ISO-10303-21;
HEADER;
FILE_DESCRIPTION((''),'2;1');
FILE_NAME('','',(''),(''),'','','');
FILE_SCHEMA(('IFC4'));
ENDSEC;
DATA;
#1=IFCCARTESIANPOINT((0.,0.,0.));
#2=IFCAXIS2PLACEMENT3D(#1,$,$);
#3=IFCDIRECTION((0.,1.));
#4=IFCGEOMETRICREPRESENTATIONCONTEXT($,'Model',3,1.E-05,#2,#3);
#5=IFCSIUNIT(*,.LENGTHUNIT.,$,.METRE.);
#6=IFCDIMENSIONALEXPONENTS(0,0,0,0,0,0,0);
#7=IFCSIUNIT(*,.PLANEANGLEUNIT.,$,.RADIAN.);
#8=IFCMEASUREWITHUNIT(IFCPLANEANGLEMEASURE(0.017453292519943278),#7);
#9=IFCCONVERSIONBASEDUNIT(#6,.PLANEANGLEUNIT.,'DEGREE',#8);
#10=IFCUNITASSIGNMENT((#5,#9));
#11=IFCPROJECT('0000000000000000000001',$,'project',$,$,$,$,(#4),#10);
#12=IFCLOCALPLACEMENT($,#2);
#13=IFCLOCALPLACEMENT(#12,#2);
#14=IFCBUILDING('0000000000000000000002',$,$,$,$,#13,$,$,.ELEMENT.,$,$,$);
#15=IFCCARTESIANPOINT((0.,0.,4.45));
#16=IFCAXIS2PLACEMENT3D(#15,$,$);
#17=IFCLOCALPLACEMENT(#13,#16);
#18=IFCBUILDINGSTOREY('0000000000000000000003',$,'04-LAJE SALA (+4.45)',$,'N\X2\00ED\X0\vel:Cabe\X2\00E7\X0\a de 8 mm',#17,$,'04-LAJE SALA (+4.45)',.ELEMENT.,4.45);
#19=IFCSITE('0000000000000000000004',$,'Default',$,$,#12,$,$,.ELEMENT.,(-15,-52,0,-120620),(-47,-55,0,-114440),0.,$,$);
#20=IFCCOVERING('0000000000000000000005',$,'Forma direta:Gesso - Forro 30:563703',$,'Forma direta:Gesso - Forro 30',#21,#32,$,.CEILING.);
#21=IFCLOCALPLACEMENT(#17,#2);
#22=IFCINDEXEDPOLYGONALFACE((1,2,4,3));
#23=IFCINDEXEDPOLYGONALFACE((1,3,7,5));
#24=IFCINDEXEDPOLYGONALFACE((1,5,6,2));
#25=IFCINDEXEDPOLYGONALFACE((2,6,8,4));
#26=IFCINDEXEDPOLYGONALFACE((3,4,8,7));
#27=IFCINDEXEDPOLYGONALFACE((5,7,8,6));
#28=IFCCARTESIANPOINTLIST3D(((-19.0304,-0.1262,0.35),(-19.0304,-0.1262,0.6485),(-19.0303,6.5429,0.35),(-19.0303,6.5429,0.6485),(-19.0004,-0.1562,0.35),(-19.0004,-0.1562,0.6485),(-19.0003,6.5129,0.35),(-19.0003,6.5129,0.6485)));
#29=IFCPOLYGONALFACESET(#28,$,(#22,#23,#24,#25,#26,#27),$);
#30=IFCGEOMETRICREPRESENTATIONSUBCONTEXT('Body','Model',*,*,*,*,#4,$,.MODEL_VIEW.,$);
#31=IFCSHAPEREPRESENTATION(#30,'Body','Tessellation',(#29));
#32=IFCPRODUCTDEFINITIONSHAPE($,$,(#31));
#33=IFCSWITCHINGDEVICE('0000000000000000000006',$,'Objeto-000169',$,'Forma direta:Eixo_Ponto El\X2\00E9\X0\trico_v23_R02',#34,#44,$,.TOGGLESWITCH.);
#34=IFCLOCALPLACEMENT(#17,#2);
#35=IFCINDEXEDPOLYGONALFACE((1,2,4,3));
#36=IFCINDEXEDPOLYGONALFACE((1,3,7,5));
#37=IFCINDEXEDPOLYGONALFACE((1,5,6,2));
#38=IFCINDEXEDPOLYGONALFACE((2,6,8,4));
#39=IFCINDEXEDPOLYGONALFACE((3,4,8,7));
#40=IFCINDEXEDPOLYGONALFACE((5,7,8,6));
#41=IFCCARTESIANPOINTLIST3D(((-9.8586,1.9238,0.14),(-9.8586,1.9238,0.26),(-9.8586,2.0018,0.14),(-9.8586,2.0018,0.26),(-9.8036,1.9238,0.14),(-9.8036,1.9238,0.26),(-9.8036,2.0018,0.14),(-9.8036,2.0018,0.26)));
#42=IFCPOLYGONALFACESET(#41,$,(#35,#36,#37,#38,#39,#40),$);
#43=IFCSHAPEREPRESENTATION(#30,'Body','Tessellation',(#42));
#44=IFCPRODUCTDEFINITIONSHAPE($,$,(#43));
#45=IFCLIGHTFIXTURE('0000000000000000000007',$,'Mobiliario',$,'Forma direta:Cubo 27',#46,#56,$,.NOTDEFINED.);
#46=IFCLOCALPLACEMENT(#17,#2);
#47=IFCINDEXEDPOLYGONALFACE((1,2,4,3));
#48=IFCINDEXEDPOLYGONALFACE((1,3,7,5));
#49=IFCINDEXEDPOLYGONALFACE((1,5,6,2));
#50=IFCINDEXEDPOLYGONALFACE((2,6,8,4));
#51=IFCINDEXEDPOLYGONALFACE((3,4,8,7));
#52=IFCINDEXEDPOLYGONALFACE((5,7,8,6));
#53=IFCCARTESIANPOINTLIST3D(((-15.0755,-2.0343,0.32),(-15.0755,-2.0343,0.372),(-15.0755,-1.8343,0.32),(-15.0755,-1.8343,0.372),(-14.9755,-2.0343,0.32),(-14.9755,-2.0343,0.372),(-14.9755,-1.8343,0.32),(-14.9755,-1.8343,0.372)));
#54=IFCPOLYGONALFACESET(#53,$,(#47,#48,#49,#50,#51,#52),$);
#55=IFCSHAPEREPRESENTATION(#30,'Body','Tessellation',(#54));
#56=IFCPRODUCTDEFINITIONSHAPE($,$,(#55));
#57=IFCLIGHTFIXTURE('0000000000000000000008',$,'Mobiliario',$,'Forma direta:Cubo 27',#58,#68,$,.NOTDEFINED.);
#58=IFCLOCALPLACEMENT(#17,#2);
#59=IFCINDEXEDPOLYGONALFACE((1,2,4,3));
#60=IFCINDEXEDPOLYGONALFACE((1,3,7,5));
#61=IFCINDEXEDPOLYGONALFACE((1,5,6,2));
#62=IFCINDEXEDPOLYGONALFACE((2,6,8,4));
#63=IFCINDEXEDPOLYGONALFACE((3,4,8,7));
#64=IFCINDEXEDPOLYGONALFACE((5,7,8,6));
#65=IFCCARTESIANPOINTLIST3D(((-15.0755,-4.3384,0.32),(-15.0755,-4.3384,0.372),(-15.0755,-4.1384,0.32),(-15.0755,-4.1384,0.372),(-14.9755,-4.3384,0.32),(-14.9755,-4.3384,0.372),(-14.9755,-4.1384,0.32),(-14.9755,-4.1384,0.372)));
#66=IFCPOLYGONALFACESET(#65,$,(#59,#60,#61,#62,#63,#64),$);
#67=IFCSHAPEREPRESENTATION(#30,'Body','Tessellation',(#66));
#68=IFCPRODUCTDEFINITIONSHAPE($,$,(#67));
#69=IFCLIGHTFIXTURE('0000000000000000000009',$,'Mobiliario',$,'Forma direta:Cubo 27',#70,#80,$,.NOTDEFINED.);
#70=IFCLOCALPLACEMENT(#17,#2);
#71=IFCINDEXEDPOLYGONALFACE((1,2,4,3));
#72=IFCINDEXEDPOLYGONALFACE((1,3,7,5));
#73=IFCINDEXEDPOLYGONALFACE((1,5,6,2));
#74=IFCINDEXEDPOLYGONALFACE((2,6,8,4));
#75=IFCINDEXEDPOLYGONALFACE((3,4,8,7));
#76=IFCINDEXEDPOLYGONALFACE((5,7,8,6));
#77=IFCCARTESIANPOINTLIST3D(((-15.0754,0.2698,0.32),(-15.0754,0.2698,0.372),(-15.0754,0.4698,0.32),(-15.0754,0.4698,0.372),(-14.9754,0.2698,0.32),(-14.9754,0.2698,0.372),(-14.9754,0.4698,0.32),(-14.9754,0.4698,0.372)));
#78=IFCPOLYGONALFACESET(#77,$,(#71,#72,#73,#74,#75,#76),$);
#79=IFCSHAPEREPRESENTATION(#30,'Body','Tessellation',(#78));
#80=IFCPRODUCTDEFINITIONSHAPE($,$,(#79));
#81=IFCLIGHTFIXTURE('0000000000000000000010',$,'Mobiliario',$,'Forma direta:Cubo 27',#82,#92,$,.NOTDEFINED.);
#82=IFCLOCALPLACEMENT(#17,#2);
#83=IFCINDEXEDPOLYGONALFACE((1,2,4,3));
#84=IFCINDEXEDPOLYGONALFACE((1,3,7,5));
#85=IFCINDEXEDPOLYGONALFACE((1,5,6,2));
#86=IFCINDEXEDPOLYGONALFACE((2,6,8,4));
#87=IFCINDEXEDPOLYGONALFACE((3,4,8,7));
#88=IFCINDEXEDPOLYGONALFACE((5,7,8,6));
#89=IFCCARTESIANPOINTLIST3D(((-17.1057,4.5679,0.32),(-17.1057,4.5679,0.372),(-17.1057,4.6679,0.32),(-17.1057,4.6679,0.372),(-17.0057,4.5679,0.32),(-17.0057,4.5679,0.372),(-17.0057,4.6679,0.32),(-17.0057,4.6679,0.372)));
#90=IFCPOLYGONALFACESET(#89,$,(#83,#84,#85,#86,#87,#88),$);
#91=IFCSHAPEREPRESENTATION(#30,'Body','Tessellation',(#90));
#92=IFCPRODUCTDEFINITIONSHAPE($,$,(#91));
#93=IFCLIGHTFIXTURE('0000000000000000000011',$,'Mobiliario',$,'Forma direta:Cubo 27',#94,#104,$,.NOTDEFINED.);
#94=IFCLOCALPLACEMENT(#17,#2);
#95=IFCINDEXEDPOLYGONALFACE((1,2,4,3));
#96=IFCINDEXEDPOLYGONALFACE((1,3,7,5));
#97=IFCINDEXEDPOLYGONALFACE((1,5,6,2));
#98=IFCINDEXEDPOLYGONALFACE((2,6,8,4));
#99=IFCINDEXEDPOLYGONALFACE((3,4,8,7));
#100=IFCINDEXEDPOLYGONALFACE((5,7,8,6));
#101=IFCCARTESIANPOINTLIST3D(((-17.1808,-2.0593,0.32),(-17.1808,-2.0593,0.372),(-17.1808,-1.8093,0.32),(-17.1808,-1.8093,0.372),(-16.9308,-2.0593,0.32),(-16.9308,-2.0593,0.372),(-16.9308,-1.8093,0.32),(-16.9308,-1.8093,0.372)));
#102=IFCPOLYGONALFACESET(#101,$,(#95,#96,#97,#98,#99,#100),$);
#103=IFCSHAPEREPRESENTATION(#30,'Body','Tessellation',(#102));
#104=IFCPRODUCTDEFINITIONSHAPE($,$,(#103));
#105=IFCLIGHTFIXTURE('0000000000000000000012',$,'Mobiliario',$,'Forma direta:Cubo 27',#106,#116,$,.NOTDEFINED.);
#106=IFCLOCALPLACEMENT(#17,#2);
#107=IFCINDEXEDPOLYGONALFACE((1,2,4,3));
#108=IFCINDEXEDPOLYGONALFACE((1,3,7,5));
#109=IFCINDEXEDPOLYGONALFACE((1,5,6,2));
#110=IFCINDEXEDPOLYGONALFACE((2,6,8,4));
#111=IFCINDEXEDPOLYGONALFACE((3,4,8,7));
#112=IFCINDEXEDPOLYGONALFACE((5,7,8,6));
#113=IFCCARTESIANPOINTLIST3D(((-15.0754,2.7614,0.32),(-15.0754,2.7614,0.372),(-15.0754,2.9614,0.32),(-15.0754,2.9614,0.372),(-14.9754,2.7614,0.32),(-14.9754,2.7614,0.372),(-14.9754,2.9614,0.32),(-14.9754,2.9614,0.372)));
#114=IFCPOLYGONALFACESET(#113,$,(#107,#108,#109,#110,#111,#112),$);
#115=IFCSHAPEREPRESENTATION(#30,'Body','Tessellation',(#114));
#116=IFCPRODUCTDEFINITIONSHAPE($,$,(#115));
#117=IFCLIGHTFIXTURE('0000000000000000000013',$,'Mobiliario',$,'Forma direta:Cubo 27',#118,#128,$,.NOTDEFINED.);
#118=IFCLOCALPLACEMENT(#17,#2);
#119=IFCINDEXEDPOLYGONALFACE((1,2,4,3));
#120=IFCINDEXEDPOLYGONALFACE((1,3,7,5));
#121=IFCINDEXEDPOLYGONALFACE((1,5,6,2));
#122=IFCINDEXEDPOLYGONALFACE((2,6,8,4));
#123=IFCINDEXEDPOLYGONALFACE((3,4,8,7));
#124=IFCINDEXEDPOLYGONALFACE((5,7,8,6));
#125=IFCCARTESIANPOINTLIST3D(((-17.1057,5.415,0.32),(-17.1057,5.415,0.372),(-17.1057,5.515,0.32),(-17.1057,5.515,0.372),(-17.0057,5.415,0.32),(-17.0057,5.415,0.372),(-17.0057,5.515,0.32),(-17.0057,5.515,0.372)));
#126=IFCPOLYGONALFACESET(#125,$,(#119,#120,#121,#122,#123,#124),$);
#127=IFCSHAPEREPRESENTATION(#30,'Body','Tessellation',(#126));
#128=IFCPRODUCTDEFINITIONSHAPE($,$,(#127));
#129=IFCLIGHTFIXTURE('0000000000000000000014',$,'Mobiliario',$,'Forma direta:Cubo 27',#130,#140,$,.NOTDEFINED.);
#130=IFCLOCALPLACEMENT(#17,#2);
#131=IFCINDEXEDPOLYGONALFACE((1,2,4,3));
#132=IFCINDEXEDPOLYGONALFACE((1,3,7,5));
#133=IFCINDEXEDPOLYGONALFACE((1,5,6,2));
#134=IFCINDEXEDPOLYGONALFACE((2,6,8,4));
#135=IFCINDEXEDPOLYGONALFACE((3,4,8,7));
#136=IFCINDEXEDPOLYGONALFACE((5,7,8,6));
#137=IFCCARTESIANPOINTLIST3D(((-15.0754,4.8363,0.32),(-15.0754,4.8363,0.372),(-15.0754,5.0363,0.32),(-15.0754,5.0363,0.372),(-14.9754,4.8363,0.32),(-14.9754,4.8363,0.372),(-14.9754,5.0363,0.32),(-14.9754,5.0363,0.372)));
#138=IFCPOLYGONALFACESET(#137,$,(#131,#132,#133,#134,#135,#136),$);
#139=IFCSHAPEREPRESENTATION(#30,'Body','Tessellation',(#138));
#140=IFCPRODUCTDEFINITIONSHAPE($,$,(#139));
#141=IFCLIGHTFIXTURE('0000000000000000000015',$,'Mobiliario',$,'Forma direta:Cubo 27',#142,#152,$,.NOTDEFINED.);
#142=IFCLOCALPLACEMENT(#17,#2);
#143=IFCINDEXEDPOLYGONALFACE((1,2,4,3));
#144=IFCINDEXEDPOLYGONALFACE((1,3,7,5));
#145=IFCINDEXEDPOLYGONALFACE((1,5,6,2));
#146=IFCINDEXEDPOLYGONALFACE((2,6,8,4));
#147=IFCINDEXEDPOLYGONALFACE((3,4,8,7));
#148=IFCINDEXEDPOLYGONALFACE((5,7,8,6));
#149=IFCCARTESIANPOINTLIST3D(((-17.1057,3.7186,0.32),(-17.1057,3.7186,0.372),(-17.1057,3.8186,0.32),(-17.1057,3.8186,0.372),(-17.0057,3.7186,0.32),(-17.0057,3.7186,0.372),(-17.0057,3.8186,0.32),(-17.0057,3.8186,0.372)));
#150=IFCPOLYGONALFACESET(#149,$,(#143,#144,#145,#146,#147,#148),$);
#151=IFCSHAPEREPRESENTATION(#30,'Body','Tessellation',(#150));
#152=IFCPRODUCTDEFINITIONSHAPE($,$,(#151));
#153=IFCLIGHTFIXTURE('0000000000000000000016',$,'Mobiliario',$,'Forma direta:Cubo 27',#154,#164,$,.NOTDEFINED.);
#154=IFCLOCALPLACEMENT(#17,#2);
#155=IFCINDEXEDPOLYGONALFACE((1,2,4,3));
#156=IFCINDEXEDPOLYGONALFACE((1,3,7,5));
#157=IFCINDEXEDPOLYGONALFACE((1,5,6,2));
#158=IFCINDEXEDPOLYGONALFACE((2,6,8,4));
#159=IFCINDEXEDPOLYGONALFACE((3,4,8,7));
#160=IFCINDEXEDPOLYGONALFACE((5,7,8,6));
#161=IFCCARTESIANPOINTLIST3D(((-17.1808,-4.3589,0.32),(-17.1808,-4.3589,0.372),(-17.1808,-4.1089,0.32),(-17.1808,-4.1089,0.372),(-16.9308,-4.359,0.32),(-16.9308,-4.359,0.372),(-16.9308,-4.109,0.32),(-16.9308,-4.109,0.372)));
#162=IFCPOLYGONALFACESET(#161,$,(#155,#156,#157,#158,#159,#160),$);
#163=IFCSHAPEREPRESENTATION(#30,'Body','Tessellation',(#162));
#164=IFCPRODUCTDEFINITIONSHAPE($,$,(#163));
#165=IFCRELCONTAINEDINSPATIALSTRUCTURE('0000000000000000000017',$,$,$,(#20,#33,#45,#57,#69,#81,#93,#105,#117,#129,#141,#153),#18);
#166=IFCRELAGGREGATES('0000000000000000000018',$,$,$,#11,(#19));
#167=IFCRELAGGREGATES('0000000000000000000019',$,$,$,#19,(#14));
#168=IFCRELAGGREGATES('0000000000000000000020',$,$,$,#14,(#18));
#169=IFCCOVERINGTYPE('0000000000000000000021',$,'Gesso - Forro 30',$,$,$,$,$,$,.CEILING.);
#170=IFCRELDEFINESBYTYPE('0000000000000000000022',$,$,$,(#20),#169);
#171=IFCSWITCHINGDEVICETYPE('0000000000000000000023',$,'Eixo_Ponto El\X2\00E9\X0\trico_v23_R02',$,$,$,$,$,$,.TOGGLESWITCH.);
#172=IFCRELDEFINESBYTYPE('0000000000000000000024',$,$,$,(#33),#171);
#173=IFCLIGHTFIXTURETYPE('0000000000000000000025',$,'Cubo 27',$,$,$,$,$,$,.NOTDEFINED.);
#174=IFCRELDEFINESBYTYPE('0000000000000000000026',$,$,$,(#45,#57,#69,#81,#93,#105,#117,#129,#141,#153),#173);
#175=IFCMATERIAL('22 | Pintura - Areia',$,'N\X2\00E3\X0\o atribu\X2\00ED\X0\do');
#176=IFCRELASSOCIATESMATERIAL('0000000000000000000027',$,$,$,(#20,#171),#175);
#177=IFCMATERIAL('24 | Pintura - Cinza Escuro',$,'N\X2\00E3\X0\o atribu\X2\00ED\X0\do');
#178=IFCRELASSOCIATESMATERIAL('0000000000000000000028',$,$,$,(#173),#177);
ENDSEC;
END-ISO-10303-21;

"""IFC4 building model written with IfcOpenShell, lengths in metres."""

from ifc_helpers import new_model, entity, si_unit, converted_unit, direction, frame, origin, place, context, subcontext, project, spatial, indexed_curve, outline, extrude, material, type_object, element, save


model = new_model("IFC4")

# Units and contexts
model_context = context("Model", 3, precision=1e-05, world=origin(), true_north=direction((0.0, 1.0)))
body_context = subcontext(model_context, "Body", "Model", "MODEL_VIEW")
ifc_project = project(units=[si_unit("LENGTHUNIT", "METRE"), converted_unit("PLANEANGLEUNIT", "DEGREE", entity("IfcPlaneAngleMeasure", 0.017453292519943278), si_unit("PLANEANGLEUNIT", "RADIAN"), dimensions=[0, 0, 0, 0, 0, 0, 0])], contexts=[model_context])

# Site, building, storey
site_placement = place(None, origin())
site = spatial("IfcSite", under=ifc_project, at=site_placement, Name="Default", CompositionType="ELEMENT", RefLatitude=(-15, -52, 0, -120620), RefLongitude=(-47, -55, 0, -114440), RefElevation=0.0)
building_placement = place(site_placement, origin())
building = spatial("IfcBuilding", under=site, at=building_placement, CompositionType="ELEMENT")
storey_placement = place(building_placement, frame((0.0, 0.0, 4.45)))
storey = spatial("IfcBuildingStorey", under=building, at=storey_placement, Name="04-LAJE SALA (+4.45)", ObjectType="Nível:Cabeça de 8 mm", LongName="04-LAJE SALA (+4.45)", CompositionType="ELEMENT", Elevation=4.45)

# Covering
ifc_material_1 = material(Name="22 | Pintura - Areia", Category="Não atribuído")
covering_type = type_object("IfcCoveringType", Name="Gesso - Forro 30", PredefinedType="CEILING")
covering_1_placement = place(storey_placement, origin())
element("IfcCovering", 1, at=covering_1_placement, inside=storey, type_object=covering_type, material=ifc_material_1, Name="Forma direta:Gesso - Forro 30:563703", ObjectType="Forma direta:Gesso - Forro 30", PredefinedType="CEILING", context=body_context, shape_type="SweptSolid", body=[
    extrude(outline(indexed_curve([(2.3367, -2.3579), (2.3791, -2.3579), (-2.3367, 2.3579), (-2.3791, 2.3579), (2.3367, -2.3579)], self_intersect=False)), frame((-19.0154, 3.1933, 0.35), z_axis=(0.0, 0.0, 1.0), x_axis=(-0.707098, 0.707116, 0.0)), (0.0, 0.0, 1.0), 0.2985),
])

# Switching device
switching_device_type = type_object("IfcSwitchingDeviceType", Name="Eixo_Ponto Elétrico_v23_R02", PredefinedType="TOGGLESWITCH", material=ifc_material_1)
switching_device_placement = place(storey_placement, origin())
element("IfcSwitchingDevice", 2, at=switching_device_placement, inside=storey, type_object=switching_device_type, Name="Objeto-000169", ObjectType="Forma direta:Eixo_Ponto Elétrico_v23_R02", PredefinedType="TOGGLESWITCH", context=body_context, shape_type="SweptSolid", body=[
    extrude(outline(indexed_curve([(-0.0275, -0.039), (0.0275, -0.039), (0.0275, 0.039), (-0.0275, 0.039), (-0.0275, -0.039)], self_intersect=False)), frame((-9.8311, 1.9628, 0.14)), (0.0, 0.0, 1.0), 0.12),
])

# Light fixtures
ifc_material_2 = material(Name="24 | Pintura - Cinza Escuro", Category="Não atribuído")
light_fixture_type = type_object("IfcLightFixtureType", Name="Cubo 27", PredefinedType="NOTDEFINED", material=ifc_material_2)
light_fixture_1_placement = place(storey_placement, origin())
element("IfcLightFixture", 3, at=light_fixture_1_placement, inside=storey, type_object=light_fixture_type, Name="Mobiliario", ObjectType="Forma direta:Cubo 27", PredefinedType="NOTDEFINED", context=body_context, shape_type="SweptSolid", body=[
    extrude(outline(indexed_curve([(-0.1, -0.05), (0.1, -0.05), (0.1, 0.05), (-0.1, 0.05), (-0.1, -0.05)], self_intersect=False)), frame((-15.0255, -1.9343, 0.32), z_axis=(0.0, 0.0, 1.0), x_axis=(-0.000013, -1.0, 0.0)), (0.0, 0.0, 1.0), 0.052),
])
light_fixture_2_placement = place(storey_placement, origin())
element("IfcLightFixture", 4, at=light_fixture_2_placement, inside=storey, type_object=light_fixture_type, Name="Mobiliario", ObjectType="Forma direta:Cubo 27", PredefinedType="NOTDEFINED", context=body_context, shape_type="SweptSolid", body=[
    extrude(outline(indexed_curve([(-0.1, -0.05), (0.1, -0.05), (0.1, 0.05), (-0.1, 0.05), (-0.1, -0.05)], self_intersect=False)), frame((-15.0255, -4.2384, 0.32), z_axis=(0.0, 0.0, 1.0), x_axis=(-0.000013, -1.0, 0.0)), (0.0, 0.0, 1.0), 0.052),
])
light_fixture_3_placement = place(storey_placement, origin())
element("IfcLightFixture", 5, at=light_fixture_3_placement, inside=storey, type_object=light_fixture_type, Name="Mobiliario", ObjectType="Forma direta:Cubo 27", PredefinedType="NOTDEFINED", context=body_context, shape_type="SweptSolid", body=[
    extrude(outline(indexed_curve([(-0.1, -0.05), (0.1, -0.05), (0.1, 0.05), (-0.1, 0.05), (-0.1, -0.05)], self_intersect=False)), frame((-15.0254, 0.3698, 0.32), z_axis=(0.0, 0.0, 1.0), x_axis=(-0.000013, -1.0, 0.0)), (0.0, 0.0, 1.0), 0.052),
])
light_fixture_4_placement = place(storey_placement, origin())
element("IfcLightFixture", 6, at=light_fixture_4_placement, inside=storey, type_object=light_fixture_type, Name="Mobiliario", ObjectType="Forma direta:Cubo 27", PredefinedType="NOTDEFINED", context=body_context, shape_type="SweptSolid", body=[
    extrude(outline(indexed_curve([(-0.05, -0.05), (0.05, -0.05), (0.05, 0.05), (-0.05, 0.05), (-0.05, -0.05)], self_intersect=False)), frame((-17.0557, 4.6179, 0.32), z_axis=(0.0, 0.0, 1.0), x_axis=(-0.000013, -1.0, 0.0)), (0.0, 0.0, 1.0), 0.052),
])
light_fixture_5_placement = place(storey_placement, origin())
element("IfcLightFixture", 7, at=light_fixture_5_placement, inside=storey, type_object=light_fixture_type, Name="Mobiliario", ObjectType="Forma direta:Cubo 27", PredefinedType="NOTDEFINED", context=body_context, shape_type="SweptSolid", body=[
    extrude(outline(indexed_curve([(-0.125, -0.125), (0.125, -0.125), (0.125, 0.125), (-0.125, 0.125), (-0.125, -0.125)], self_intersect=False)), frame((-17.0558, -1.9343, 0.32), z_axis=(0.0, 0.0, 1.0), x_axis=(-0.000013, -1.0, 0.0)), (0.0, 0.0, 1.0), 0.052),
])
light_fixture_6_placement = place(storey_placement, origin())
element("IfcLightFixture", 8, at=light_fixture_6_placement, inside=storey, type_object=light_fixture_type, Name="Mobiliario", ObjectType="Forma direta:Cubo 27", PredefinedType="NOTDEFINED", context=body_context, shape_type="SweptSolid", body=[
    extrude(outline(indexed_curve([(-0.1, -0.05), (0.1, -0.05), (0.1, 0.05), (-0.1, 0.05), (-0.1, -0.05)], self_intersect=False)), frame((-15.0254, 2.8614, 0.32), z_axis=(0.0, 0.0, 1.0), x_axis=(-0.000013, -1.0, 0.0)), (0.0, 0.0, 1.0), 0.052),
])
light_fixture_7_placement = place(storey_placement, origin())
element("IfcLightFixture", 9, at=light_fixture_7_placement, inside=storey, type_object=light_fixture_type, Name="Mobiliario", ObjectType="Forma direta:Cubo 27", PredefinedType="NOTDEFINED", context=body_context, shape_type="SweptSolid", body=[
    extrude(outline(indexed_curve([(-0.05, -0.05), (0.05, -0.05), (0.05, 0.05), (-0.05, 0.05), (-0.05, -0.05)], self_intersect=False)), frame((-17.0557, 5.465, 0.32), z_axis=(0.0, 0.0, 1.0), x_axis=(-0.000013, -1.0, 0.0)), (0.0, 0.0, 1.0), 0.052),
])
light_fixture_8_placement = place(storey_placement, origin())
element("IfcLightFixture", 10, at=light_fixture_8_placement, inside=storey, type_object=light_fixture_type, Name="Mobiliario", ObjectType="Forma direta:Cubo 27", PredefinedType="NOTDEFINED", context=body_context, shape_type="SweptSolid", body=[
    extrude(outline(indexed_curve([(-0.1, -0.05), (0.1, -0.05), (0.1, 0.05), (-0.1, 0.05), (-0.1, -0.05)], self_intersect=False)), frame((-15.0254, 4.9363, 0.32), z_axis=(0.0, 0.0, 1.0), x_axis=(-0.000013, -1.0, 0.0)), (0.0, 0.0, 1.0), 0.052),
])
light_fixture_9_placement = place(storey_placement, origin())
element("IfcLightFixture", 11, at=light_fixture_9_placement, inside=storey, type_object=light_fixture_type, Name="Mobiliario", ObjectType="Forma direta:Cubo 27", PredefinedType="NOTDEFINED", context=body_context, shape_type="SweptSolid", body=[
    extrude(outline(indexed_curve([(-0.05, -0.05), (0.05, -0.05), (0.05, 0.05), (-0.05, 0.05), (-0.05, -0.05)], self_intersect=False)), frame((-17.0557, 3.7686, 0.32), z_axis=(0.0, 0.0, 1.0), x_axis=(-0.000013, -1.0, 0.0)), (0.0, 0.0, 1.0), 0.052),
])
light_fixture_10_placement = place(storey_placement, origin())
element("IfcLightFixture", 12, at=light_fixture_10_placement, inside=storey, type_object=light_fixture_type, Name="Mobiliario", ObjectType="Forma direta:Cubo 27", PredefinedType="NOTDEFINED", context=body_context, shape_type="SweptSolid", body=[
    extrude(outline(indexed_curve([(-0.125, -0.125), (0.125, -0.125), (0.125, 0.125), (-0.125, 0.125), (-0.125, -0.125)], self_intersect=False)), frame((-17.0558, -4.2339, 0.32), z_axis=(0.0, 0.0, 1.0), x_axis=(-0.000013, -1.0, 0.0)), (0.0, 0.0, 1.0), 0.052),
])

save(model, "model.ifc")
